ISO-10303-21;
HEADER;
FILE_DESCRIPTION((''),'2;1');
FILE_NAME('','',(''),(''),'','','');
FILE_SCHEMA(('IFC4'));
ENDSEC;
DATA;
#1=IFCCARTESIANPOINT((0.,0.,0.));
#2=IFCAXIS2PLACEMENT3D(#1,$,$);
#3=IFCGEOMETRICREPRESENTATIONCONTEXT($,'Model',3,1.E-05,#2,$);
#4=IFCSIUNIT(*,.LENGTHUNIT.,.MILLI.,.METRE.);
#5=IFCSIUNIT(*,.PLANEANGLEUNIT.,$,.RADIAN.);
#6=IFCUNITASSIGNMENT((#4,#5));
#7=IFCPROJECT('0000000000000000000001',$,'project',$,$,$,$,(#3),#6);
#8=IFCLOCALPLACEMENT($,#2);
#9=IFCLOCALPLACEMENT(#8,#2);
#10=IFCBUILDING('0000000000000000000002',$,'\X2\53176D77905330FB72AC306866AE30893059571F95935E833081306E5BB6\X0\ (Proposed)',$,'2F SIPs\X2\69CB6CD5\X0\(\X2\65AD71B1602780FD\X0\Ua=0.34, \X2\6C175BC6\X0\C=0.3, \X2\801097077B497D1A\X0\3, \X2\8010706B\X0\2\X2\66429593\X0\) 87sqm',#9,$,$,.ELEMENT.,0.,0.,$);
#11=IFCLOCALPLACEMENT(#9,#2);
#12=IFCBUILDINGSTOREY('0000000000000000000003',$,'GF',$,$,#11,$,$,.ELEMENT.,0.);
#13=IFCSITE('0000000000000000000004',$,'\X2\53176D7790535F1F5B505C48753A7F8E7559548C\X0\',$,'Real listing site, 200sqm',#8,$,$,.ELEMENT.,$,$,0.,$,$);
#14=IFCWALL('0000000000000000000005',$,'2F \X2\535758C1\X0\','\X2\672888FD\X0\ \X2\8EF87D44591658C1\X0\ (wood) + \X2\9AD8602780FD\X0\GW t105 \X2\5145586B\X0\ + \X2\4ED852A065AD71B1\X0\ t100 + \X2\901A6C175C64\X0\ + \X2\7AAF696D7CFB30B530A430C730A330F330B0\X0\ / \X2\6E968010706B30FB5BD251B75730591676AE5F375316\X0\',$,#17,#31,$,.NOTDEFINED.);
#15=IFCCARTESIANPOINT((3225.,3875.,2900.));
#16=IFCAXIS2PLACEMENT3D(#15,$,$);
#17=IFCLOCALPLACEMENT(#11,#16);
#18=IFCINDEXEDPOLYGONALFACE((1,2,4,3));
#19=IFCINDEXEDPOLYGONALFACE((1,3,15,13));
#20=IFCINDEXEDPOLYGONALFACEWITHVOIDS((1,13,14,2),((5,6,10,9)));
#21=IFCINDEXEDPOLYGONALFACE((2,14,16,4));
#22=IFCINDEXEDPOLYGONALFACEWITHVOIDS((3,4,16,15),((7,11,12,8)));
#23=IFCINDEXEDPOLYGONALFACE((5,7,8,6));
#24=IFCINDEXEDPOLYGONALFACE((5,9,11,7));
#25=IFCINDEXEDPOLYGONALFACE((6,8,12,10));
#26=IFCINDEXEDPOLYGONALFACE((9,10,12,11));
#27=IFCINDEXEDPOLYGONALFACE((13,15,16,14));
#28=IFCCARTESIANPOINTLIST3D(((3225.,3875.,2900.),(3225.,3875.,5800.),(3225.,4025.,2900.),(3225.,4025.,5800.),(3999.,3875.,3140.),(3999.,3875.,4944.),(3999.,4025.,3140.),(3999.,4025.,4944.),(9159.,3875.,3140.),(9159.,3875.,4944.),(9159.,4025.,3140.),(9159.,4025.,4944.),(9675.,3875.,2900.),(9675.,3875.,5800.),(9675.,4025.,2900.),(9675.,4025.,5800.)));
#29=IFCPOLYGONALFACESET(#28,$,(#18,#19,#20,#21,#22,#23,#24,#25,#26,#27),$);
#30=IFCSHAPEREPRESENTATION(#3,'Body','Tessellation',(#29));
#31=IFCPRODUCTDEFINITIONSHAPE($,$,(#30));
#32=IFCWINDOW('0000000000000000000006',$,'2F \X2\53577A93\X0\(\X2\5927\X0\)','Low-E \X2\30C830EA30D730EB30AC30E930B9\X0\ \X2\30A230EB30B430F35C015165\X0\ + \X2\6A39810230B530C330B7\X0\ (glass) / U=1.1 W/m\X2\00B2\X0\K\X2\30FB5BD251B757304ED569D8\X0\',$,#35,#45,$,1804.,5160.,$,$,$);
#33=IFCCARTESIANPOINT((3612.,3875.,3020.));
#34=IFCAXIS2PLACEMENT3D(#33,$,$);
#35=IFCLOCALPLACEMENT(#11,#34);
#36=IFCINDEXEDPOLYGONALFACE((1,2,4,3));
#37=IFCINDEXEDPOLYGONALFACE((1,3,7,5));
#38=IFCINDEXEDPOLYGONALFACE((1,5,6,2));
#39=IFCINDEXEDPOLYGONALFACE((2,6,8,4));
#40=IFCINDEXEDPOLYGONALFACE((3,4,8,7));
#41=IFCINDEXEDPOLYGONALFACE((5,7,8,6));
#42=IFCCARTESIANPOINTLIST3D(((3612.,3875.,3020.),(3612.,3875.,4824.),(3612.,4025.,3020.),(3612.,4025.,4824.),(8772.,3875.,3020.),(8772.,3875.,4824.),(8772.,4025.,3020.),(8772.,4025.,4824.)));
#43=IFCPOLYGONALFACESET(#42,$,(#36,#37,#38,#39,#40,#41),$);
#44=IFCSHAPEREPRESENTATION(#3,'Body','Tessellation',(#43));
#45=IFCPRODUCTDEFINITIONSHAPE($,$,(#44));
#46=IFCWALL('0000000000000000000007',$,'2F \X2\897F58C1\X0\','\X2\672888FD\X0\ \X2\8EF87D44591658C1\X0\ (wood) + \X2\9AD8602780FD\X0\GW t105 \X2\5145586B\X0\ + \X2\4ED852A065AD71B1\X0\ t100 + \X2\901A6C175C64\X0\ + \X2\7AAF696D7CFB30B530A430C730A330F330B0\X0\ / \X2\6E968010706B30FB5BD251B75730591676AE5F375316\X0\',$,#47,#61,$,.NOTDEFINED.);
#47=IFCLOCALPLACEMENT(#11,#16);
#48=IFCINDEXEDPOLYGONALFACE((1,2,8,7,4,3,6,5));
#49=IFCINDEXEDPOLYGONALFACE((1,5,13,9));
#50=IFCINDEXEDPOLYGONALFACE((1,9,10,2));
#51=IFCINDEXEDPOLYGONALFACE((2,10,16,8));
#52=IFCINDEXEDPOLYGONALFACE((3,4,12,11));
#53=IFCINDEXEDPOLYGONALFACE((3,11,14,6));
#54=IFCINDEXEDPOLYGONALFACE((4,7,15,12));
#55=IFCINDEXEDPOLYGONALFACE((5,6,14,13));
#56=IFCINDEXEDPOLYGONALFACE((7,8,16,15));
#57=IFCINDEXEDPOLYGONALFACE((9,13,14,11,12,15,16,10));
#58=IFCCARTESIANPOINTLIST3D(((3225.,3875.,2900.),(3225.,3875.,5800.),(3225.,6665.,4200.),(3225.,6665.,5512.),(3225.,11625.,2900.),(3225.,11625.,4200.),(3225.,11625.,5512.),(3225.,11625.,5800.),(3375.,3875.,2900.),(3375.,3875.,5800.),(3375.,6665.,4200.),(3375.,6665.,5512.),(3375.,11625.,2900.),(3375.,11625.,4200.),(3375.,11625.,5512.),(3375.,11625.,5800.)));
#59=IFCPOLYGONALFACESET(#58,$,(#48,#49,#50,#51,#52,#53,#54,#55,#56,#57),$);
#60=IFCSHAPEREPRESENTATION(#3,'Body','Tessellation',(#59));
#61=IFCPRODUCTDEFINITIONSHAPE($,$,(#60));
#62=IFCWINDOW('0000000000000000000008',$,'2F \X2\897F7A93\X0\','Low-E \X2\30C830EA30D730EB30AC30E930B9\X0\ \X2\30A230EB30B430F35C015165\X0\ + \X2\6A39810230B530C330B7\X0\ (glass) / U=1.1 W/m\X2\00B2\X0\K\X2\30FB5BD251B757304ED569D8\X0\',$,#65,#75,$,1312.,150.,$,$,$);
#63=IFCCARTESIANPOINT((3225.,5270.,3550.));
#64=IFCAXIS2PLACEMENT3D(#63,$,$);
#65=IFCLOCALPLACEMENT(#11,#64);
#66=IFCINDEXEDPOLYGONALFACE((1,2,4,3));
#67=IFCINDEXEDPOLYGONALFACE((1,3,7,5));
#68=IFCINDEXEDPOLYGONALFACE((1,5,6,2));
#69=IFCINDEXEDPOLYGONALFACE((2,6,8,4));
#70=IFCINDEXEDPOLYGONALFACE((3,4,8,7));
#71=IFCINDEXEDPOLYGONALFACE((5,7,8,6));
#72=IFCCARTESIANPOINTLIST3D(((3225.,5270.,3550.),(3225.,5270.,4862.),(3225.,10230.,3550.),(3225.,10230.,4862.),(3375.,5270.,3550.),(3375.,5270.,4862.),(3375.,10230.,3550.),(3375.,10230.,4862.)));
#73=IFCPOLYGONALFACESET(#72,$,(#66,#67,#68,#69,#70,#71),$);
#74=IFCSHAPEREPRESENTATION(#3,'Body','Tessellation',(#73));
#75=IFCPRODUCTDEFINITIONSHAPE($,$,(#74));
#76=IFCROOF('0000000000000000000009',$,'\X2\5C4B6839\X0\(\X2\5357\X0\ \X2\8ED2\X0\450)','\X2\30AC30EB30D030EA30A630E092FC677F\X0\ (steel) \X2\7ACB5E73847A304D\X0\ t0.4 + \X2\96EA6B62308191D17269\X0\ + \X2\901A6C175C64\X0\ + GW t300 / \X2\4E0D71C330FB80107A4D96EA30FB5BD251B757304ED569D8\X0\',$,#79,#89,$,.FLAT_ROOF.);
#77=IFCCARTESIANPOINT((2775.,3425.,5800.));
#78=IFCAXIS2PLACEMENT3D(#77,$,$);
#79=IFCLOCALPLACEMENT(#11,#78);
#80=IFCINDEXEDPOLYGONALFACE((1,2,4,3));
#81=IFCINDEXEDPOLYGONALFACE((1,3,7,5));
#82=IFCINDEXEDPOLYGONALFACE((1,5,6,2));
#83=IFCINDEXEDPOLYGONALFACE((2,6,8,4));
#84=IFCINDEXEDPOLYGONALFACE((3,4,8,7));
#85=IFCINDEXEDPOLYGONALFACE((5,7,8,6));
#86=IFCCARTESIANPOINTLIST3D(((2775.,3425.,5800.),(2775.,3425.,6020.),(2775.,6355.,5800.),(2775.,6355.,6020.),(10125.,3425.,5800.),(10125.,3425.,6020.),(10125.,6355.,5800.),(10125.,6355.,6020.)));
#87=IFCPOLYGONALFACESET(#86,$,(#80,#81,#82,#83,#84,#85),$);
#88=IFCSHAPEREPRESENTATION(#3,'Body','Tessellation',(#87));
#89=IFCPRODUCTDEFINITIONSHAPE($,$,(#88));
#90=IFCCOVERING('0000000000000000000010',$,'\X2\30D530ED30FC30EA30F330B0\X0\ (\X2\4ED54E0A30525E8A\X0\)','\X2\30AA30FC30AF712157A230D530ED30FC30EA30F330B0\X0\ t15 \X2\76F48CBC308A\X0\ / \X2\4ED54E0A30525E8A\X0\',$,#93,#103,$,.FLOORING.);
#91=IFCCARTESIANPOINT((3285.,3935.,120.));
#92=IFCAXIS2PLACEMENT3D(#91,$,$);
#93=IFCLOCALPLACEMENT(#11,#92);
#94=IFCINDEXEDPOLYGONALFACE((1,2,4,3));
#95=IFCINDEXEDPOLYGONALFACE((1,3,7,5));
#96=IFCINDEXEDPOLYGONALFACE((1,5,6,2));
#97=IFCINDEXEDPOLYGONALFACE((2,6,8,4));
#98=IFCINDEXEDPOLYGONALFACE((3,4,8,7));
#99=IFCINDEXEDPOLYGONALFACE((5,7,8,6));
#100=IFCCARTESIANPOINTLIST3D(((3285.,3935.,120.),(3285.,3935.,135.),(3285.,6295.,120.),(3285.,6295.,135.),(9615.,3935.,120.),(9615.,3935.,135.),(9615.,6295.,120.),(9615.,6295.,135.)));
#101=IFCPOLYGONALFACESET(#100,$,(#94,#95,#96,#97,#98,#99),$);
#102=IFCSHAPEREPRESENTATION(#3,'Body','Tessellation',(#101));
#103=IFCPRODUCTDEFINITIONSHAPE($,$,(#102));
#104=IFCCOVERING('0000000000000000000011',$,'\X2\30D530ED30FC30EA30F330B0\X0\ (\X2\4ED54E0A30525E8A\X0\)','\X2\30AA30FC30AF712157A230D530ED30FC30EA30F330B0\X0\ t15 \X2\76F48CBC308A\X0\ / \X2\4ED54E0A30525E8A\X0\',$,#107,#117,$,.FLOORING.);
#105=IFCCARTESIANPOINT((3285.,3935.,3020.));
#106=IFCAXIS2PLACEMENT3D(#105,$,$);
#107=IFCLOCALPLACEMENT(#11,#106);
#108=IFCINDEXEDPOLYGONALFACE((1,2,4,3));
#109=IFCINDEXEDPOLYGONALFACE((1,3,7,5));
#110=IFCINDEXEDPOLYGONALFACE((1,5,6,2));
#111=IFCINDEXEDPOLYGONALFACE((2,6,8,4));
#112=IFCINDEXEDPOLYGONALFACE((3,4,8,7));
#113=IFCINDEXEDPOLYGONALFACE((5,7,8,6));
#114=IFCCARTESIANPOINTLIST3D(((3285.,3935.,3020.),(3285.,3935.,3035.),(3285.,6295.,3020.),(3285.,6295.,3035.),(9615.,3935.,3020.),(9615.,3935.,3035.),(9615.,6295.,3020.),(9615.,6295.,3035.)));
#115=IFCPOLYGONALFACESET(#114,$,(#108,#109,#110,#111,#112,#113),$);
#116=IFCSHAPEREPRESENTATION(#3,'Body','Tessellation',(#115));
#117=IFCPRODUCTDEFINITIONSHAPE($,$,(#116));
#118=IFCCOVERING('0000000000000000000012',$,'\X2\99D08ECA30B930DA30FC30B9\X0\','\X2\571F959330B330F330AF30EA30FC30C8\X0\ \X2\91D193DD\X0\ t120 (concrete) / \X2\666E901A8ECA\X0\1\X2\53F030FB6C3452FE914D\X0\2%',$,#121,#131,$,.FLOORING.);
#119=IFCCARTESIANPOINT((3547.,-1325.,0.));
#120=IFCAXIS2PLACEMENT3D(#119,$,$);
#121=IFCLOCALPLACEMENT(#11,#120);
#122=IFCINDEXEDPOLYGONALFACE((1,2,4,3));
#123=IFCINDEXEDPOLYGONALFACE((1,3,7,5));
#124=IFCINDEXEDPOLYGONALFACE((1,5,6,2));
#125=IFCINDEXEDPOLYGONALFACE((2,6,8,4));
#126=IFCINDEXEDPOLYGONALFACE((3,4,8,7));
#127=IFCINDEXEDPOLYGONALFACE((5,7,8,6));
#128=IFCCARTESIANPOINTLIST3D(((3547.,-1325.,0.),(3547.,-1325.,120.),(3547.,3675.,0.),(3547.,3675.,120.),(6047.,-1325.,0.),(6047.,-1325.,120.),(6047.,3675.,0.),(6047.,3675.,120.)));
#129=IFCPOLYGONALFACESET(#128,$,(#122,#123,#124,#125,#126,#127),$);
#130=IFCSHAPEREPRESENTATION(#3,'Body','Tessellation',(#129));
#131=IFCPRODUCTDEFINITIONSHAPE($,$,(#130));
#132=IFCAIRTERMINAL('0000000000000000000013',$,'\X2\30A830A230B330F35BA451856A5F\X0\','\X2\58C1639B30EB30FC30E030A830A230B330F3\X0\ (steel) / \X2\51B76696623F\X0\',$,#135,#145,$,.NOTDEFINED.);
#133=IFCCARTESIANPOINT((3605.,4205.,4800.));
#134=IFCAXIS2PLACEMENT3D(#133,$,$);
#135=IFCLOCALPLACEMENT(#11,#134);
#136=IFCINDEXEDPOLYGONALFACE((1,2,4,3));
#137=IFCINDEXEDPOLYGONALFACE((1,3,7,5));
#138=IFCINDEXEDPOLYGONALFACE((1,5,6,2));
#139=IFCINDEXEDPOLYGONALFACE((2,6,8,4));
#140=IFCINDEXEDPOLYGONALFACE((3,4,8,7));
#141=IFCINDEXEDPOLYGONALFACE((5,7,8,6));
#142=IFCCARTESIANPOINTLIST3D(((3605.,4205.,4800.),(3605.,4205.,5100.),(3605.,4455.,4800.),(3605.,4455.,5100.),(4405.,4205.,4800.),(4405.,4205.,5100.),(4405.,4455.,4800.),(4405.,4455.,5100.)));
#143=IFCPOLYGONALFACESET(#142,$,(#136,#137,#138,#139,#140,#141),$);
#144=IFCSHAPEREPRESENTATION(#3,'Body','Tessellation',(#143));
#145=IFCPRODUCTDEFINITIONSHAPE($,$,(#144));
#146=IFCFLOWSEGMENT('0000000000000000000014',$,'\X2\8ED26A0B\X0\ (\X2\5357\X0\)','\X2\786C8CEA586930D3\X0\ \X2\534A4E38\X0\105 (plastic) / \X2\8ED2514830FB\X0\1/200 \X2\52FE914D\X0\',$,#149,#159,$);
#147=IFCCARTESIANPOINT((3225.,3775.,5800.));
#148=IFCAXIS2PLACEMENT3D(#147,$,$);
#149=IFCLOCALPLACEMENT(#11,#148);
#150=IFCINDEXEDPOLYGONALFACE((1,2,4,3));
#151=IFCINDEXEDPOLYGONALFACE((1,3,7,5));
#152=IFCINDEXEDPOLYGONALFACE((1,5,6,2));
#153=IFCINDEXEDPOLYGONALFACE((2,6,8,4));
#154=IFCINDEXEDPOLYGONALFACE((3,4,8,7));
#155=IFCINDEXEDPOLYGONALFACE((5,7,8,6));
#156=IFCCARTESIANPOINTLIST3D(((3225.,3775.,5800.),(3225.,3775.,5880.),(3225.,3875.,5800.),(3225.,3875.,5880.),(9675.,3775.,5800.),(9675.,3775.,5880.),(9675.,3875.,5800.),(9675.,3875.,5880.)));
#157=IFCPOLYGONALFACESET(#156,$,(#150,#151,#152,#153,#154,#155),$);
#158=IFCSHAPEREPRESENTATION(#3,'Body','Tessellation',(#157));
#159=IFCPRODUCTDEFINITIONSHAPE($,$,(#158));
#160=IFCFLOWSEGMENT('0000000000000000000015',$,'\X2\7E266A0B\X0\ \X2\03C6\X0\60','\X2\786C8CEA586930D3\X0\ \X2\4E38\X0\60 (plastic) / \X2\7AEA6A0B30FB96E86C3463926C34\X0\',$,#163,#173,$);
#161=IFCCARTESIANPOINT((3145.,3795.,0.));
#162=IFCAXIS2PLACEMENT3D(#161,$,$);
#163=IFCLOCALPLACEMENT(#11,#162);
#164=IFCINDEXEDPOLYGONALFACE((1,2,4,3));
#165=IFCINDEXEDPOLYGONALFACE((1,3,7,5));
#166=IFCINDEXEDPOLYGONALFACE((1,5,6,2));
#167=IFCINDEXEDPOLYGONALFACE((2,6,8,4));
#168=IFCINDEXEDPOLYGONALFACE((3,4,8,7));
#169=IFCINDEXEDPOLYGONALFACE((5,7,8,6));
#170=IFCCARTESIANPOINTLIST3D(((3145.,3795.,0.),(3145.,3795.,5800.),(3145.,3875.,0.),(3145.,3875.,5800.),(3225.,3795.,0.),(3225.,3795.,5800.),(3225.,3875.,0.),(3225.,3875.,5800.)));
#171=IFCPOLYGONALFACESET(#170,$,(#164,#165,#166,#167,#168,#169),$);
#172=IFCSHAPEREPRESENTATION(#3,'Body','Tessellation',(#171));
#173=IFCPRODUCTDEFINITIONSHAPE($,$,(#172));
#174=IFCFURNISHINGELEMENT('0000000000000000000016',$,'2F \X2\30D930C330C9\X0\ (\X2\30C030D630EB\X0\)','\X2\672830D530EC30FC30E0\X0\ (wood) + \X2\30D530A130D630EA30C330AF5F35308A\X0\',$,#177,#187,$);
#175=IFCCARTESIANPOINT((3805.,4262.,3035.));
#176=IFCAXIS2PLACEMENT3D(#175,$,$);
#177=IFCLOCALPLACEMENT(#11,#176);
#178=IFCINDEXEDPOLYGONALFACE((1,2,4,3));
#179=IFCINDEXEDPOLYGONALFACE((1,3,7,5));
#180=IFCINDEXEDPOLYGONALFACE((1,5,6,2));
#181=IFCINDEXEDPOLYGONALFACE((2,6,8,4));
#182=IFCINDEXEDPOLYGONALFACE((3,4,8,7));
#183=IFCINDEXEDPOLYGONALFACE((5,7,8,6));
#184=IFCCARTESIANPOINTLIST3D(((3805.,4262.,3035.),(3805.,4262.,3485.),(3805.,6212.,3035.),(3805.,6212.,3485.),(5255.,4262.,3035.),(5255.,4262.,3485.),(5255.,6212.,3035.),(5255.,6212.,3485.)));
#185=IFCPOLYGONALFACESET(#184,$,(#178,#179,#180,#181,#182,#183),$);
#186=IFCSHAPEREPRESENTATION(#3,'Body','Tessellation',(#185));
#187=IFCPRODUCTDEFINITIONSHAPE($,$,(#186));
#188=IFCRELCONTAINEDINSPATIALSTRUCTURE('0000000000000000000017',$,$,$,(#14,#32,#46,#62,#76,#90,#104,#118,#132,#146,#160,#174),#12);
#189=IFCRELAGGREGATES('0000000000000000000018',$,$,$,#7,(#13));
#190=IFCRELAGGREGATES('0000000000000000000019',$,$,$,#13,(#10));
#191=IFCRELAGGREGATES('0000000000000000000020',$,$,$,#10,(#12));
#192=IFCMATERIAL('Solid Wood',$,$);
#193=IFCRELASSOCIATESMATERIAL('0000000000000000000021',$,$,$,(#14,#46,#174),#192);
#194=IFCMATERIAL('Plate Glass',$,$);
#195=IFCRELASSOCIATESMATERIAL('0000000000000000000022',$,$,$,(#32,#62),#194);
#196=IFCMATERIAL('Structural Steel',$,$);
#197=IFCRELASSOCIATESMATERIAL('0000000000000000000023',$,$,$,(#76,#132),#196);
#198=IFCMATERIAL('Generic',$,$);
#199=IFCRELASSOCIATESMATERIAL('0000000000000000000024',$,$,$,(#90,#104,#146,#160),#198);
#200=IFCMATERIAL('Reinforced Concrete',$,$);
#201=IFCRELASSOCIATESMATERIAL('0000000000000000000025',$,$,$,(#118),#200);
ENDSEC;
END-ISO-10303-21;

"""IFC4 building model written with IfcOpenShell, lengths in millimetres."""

from ifc_helpers import new_model, si_unit, frame, frame_2d, origin, place, context, project, spatial, rectangle, extrude, material, element, fill, save


model = new_model("IFC4")

# Units and contexts
model_context = context("Model", 3, precision=1e-05, world=origin())
ifc_project = project(units=[si_unit("LENGTHUNIT", "METRE", prefix="MILLI"), si_unit("PLANEANGLEUNIT", "RADIAN")], contexts=[model_context])

# Site, building, storey
site_placement = place(None, origin())
site = spatial("IfcSite", under=ifc_project, at=site_placement, Name="北海道弟子屈町美留和", ObjectType="Real listing site, 200sqm", CompositionType="ELEMENT", RefElevation=0.0)
building_placement = place(site_placement, origin())
building = spatial("IfcBuilding", under=site, at=building_placement, Name="北海道・犬と暮らす土間広めの家 (Proposed)", ObjectType="2F SIPs構法(断熱性能Ua=0.34, 気密C=0.3, 耐震等級3, 耐火2時間) 87sqm", CompositionType="ELEMENT", ElevationOfRefHeight=0.0, ElevationOfTerrain=0.0)
storey_placement = place(building_placement, origin())
storey = spatial("IfcBuildingStorey", under=building, at=storey_placement, Name="GF", CompositionType="ELEMENT", Elevation=0.0)

# Shared definitions
ifc_material_1 = material(Name="Solid Wood")

# Shared definitions
ifc_material_2 = material(Name="Reinforced Concrete")

# Shared definitions
ifc_material_3 = material(Name="Plate Glass")

# Walls, openings, windows
wall_1_placement = place(storey_placement, frame((3225.0, 3875.0, 2900.0)))
wall_1 = element("IfcWall", 1, at=wall_1_placement, inside=storey, material=ifc_material_1, Name="2F 南壁", Description="木製 軸組外壁 (wood) + 高性能GW t105 充填 + 付加断熱 t100 + 通気層 + 窯業系サイディング / 準耐火・寒冷地外皮強化", PredefinedType="NOTDEFINED", context=model_context, shape_type="SweptSolid", body=[
    extrude(rectangle(XDim=6450.0, YDim=150.0, at=frame_2d((3225.0, 75.0))), frame((3225.0, 3875.0, 2900.0)), (0.0, 0.0, 1.0), 2900.0),
])
opening_1_placement = place(storey_placement, frame((3612.0, 3875.0, 3020.0)))
opening_1 = element("IfcOpeningElement", 2, at=opening_1_placement, cuts=wall_1, PredefinedType="NOTDEFINED", context=model_context, shape_type="SweptSolid", body=[
    extrude(rectangle(XDim=5160.0, YDim=150.0, at=frame_2d((2580.0, 75.0))), frame((3612.0, 3875.0, 3020.0)), (0.0, 0.0, 1.0), 1804.0),
])
window_1_placement = place(storey_placement, frame((3612.0, 3875.0, 3020.0)))
window_1 = element("IfcWindow", 3, at=window_1_placement, inside=storey, material=ifc_material_3, Name="2F 南窓(大)", Description="Low-E トリプルガラス アルゴン封入 + 樹脂サッシ (glass) / U=1.1 W/m²K・寒冷地仕様", OverallHeight=1804.0, OverallWidth=5160.0, context=model_context, shape_type="SweptSolid", body=[
    extrude(rectangle(XDim=5160.0, YDim=150.0, at=frame_2d((2580.0, 75.0))), frame((3612.0, 3875.0, 3020.0)), (0.0, 0.0, 1.0), 1804.0),
])
fill(opening_1, window_1)
wall_2_placement = place(storey_placement, frame((3225.0, 3875.0, 2900.0)))
wall_2 = element("IfcWall", 4, at=wall_2_placement, inside=storey, material=ifc_material_1, Name="2F 西壁", Description="木製 軸組外壁 (wood) + 高性能GW t105 充填 + 付加断熱 t100 + 通気層 + 窯業系サイディング / 準耐火・寒冷地外皮強化", PredefinedType="NOTDEFINED", context=model_context, shape_type="SweptSolid", body=[
    extrude(rectangle(XDim=150.0, YDim=7750.0, at=frame_2d((75.0, 3875.0))), frame((3225.0, 3875.0, 2900.0)), (0.0, 0.0, 1.0), 2900.0),
])
opening_2_placement = place(storey_placement, frame((3225.0, 5270.0, 3550.0)))
opening_2 = element("IfcOpeningElement", 5, at=opening_2_placement, cuts=wall_2, PredefinedType="NOTDEFINED", context=model_context, shape_type="SweptSolid", body=[
    extrude(rectangle(XDim=150.0, YDim=4960.0, at=frame_2d((75.0, 2480.0))), frame((3225.0, 5270.0, 3550.0)), (0.0, 0.0, 1.0), 1312.0),
])
window_2_placement = place(storey_placement, frame((3225.0, 5270.0, 3550.0)))
window_2 = element("IfcWindow", 6, at=window_2_placement, inside=storey, material=ifc_material_3, Name="2F 西窓", Description="Low-E トリプルガラス アルゴン封入 + 樹脂サッシ (glass) / U=1.1 W/m²K・寒冷地仕様", OverallHeight=1312.0, OverallWidth=150.0, context=model_context, shape_type="SweptSolid", body=[
    extrude(rectangle(XDim=150.0, YDim=4960.0, at=frame_2d((75.0, 2480.0))), frame((3225.0, 5270.0, 3550.0)), (0.0, 0.0, 1.0), 1312.0),
])
fill(opening_2, window_2)

# Roof
ifc_material_4 = material(Name="Structural Steel")
for number, where, name in (
    (7, (2775.0, 3425.0, 5800.0), "屋根(南 軒450)"),
):
    element("IfcRoof", number, at=place(storey_placement, frame(where)), inside=storey, material=ifc_material_4, Name=name, Description="ガルバリウム鋼板 (steel) 立平葺き t0.4 + 雪止め金物 + 通気層 + GW t300 / 不燃・耐積雪・寒冷地仕様", PredefinedType="FLAT_ROOF", context=model_context, shape_type="SweptSolid", body=[
        extrude(rectangle(XDim=7350.0, YDim=2930.0, at=frame_2d((3675.0, 1465.0))), frame((2775.0, 3425.0, 5800.0)), (0.0, 0.0, 1.0), 220.0),
    ])

# Coverings
ifc_material_5 = material(Name="Generic")
covering_1_placement = place(storey_placement, frame((3285.0, 3935.0, 120.0)))
element("IfcCovering", 8, at=covering_1_placement, inside=storey, material=ifc_material_5, Name="フローリング (仕上げ床)", Description="オーク無垢フローリング t15 直貼り / 仕上げ床", PredefinedType="FLOORING", context=model_context, shape_type="SweptSolid", body=[
    extrude(rectangle(XDim=6330.0, YDim=2360.0, at=frame_2d((3165.0, 1180.0))), frame((3285.0, 3935.0, 120.0)), (0.0, 0.0, 1.0), 15.0),
])
covering_2_placement = place(storey_placement, frame((3285.0, 3935.0, 3020.0)))
element("IfcCovering", 9, at=covering_2_placement, inside=storey, material=ifc_material_5, Name="フローリング (仕上げ床)", Description="オーク無垢フローリング t15 直貼り / 仕上げ床", PredefinedType="FLOORING", context=model_context, shape_type="SweptSolid", body=[
    extrude(rectangle(XDim=6330.0, YDim=2360.0, at=frame_2d((3165.0, 1180.0))), frame((3285.0, 3935.0, 3020.0)), (0.0, 0.0, 1.0), 15.0),
])
covering_3_placement = place(storey_placement, frame((3547.0, -1325.0, 0.0)))
element("IfcCovering", 10, at=covering_3_placement, inside=storey, material=ifc_material_2, Name="駐車スペース", Description="土間コンクリート 金鏝 t120 (concrete) / 普通車1台・水勾配2%", PredefinedType="FLOORING", context=model_context, shape_type="SweptSolid", body=[
    extrude(rectangle(XDim=2500.0, YDim=5000.0, at=frame_2d((1250.0, 2500.0))), frame((3547.0, -1325.0, 0.0)), (0.0, 0.0, 1.0), 120.0),
])

# Air terminal
air_terminal_placement = place(storey_placement, frame((3605.0, 4205.0, 4800.0)))
element("IfcAirTerminal", 11, at=air_terminal_placement, inside=storey, material=ifc_material_4, Name="エアコン室内機", Description="壁掛ルームエアコン (steel) / 冷暖房", PredefinedType="NOTDEFINED", context=model_context, shape_type="SweptSolid", body=[
    extrude(rectangle(XDim=800.0, YDim=250.0, at=frame_2d((400.0, 125.0))), frame((3605.0, 4205.0, 4800.0)), (0.0, 0.0, 1.0), 300.0),
])

# Flow segments
flow_segment_1_placement = place(storey_placement, frame((3225.0, 3775.0, 5800.0)))
element("IfcFlowSegment", 12, at=flow_segment_1_placement, inside=storey, material=ifc_material_5, Name="軒樋 (南)", Description="硬質塩ビ 半丸105 (plastic) / 軒先・1/200 勾配", context=model_context, shape_type="SweptSolid", body=[
    extrude(rectangle(XDim=6450.0, YDim=100.0, at=frame_2d((3225.0, 50.0))), frame((3225.0, 3775.0, 5800.0)), (0.0, 0.0, 1.0), 80.0),
])
flow_segment_2_placement = place(storey_placement, frame((3145.0, 3795.0, 0.0)))
element("IfcFlowSegment", 13, at=flow_segment_2_placement, inside=storey, material=ifc_material_5, Name="縦樋 φ60", Description="硬質塩ビ 丸60 (plastic) / 竪樋・雨水排水", context=model_context, shape_type="SweptSolid", body=[
    extrude(rectangle(XDim=80.0, YDim=80.0, at=frame_2d((40.0, 40.0))), frame((3145.0, 3795.0, 0.0)), (0.0, 0.0, 1.0), 5800.0),
])

# Furnishing element
furnishing_placement = place(storey_placement, frame((3805.0, 4262.0, 3035.0)))
element("IfcFurnishingElement", 14, at=furnishing_placement, inside=storey, material=ifc_material_1, Name="2F ベッド (ダブル)", Description="木フレーム (wood) + ファブリック張り", context=model_context, shape_type="SweptSolid", body=[
    extrude(rectangle(XDim=1450.0, YDim=1950.0, at=frame_2d((725.0, 975.0))), frame((3805.0, 4262.0, 3035.0)), (0.0, 0.0, 1.0), 450.0),
])

save(model, "model.ifc")
